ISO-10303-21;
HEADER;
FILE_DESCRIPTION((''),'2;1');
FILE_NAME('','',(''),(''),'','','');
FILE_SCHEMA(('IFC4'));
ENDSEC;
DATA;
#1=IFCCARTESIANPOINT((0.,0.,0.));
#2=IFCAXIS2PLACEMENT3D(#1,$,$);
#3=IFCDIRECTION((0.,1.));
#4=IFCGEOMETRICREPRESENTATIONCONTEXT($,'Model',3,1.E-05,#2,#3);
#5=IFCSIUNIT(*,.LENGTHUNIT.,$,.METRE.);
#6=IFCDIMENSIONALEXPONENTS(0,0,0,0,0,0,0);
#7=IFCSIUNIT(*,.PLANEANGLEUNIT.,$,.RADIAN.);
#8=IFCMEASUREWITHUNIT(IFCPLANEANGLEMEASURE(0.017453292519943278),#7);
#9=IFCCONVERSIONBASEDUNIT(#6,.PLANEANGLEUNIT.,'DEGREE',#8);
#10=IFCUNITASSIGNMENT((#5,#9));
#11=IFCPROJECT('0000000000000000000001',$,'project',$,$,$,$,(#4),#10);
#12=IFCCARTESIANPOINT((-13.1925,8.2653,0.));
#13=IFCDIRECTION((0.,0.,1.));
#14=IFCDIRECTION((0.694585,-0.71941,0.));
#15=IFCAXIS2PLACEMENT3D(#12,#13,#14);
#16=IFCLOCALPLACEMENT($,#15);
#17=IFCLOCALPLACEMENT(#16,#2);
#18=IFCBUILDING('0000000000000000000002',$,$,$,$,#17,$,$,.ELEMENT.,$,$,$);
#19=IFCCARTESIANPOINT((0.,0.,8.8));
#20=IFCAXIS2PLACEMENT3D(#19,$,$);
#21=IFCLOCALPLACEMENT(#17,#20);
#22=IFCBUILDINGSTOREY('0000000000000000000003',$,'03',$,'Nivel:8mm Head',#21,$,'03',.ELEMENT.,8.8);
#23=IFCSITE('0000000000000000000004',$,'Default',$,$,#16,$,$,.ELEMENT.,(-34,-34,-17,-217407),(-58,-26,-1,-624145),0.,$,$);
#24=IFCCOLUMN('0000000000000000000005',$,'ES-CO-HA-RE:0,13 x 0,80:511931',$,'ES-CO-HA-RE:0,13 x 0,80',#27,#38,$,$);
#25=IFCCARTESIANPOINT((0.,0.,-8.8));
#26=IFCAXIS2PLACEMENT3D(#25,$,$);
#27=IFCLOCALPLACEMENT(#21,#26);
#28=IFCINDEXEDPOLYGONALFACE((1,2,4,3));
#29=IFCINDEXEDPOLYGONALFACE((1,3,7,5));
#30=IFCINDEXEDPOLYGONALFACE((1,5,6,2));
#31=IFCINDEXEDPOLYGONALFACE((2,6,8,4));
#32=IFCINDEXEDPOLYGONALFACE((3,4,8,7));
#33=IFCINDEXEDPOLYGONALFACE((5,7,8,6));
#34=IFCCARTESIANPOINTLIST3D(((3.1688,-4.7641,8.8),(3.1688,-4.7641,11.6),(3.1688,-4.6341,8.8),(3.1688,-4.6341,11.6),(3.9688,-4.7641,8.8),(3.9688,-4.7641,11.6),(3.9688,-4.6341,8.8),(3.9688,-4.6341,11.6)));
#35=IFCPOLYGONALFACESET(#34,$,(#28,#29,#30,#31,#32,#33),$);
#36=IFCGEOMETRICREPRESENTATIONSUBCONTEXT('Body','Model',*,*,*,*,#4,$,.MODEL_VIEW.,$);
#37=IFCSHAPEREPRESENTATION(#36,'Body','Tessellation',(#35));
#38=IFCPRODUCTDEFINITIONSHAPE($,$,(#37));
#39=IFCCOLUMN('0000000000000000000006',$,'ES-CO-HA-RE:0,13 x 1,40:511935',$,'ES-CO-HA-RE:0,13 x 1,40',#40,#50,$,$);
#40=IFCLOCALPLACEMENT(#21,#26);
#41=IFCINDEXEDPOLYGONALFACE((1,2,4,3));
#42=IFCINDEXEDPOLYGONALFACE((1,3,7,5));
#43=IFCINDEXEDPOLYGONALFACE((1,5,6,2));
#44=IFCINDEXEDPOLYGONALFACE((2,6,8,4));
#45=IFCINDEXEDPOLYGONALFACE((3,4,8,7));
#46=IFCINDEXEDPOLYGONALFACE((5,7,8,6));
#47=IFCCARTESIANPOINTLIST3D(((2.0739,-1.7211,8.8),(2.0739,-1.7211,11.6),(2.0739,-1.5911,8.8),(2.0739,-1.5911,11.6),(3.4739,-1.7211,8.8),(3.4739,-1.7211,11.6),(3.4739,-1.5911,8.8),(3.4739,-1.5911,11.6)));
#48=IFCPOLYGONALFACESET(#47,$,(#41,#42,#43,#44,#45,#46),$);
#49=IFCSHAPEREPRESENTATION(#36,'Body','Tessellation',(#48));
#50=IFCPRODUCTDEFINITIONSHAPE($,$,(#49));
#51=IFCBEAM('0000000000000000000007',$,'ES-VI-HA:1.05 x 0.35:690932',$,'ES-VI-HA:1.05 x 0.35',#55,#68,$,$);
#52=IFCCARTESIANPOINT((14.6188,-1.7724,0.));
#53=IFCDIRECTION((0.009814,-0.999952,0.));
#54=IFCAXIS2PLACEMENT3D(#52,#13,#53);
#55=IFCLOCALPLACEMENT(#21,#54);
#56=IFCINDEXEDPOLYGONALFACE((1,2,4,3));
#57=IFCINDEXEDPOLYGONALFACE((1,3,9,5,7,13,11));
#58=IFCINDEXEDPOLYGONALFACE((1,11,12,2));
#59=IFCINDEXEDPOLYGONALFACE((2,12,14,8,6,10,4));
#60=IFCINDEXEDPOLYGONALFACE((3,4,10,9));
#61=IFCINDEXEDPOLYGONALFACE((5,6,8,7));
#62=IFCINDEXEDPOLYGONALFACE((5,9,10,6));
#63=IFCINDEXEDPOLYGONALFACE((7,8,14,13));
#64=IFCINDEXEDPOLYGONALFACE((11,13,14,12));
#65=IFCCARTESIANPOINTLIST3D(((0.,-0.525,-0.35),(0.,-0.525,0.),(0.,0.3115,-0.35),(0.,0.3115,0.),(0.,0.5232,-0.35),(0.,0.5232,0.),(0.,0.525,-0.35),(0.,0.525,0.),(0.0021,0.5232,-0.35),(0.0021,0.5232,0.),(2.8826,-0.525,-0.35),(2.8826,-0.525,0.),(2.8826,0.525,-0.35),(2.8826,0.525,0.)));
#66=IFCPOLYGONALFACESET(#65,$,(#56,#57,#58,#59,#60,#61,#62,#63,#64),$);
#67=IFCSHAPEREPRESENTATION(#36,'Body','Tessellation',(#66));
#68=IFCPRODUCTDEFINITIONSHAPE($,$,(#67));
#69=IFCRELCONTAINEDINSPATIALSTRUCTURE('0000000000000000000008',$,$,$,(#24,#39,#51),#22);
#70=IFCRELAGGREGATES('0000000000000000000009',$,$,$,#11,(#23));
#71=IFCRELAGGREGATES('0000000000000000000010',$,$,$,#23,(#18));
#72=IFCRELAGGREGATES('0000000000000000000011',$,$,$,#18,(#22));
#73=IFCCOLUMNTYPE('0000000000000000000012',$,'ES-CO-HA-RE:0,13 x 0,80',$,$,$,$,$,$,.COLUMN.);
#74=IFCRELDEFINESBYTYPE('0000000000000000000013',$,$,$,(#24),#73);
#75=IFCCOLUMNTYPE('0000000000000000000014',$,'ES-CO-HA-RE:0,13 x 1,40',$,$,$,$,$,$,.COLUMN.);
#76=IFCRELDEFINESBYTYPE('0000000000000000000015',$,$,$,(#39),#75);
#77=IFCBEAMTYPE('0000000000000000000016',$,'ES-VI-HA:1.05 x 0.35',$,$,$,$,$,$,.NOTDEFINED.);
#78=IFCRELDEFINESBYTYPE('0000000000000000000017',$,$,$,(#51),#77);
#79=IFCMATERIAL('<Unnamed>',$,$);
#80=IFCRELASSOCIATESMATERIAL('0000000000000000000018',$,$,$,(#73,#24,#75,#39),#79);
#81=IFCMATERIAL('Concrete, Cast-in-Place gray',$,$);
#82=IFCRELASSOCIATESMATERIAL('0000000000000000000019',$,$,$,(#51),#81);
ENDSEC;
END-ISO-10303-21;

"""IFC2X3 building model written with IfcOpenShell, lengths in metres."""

from ifc_helpers import new_model, entity, si_unit, converted_unit, direction, frame, frame_2d, origin, place, context, subcontext, project, spatial, polyline, rectangle, extrude, clip, bounded_halfspace, source, transform, mapped, material, type_object, type_shapes, element, save


model = new_model("IFC2X3")

# Units and contexts
model_context = context("Model", 3, precision=1e-05, world=origin(), true_north=direction((0.0, 1.0)))
body_context = subcontext(model_context, "Body", "Model", "MODEL_VIEW")
ifc_project = project(units=[si_unit("LENGTHUNIT", "METRE"), converted_unit("PLANEANGLEUNIT", "DEGREE", entity("IfcPlaneAngleMeasure", 0.017453292519943278), si_unit("PLANEANGLEUNIT", "RADIAN"), dimensions=[0, 0, 0, 0, 0, 0, 0])], contexts=[model_context])

# Site, building, storey
site_placement = place(None, frame((-13.1925, 8.2653, 0.0), z_axis=(0.0, 0.0, 1.0), x_axis=(0.694585, -0.71941, 0.0)))
site = spatial("IfcSite", under=ifc_project, at=site_placement, Name="Default", CompositionType="ELEMENT", RefLatitude=(-34, -34, -17, -217407), RefLongitude=(-58, -26, -1, -624145), RefElevation=0.0)
building_placement = place(site_placement, origin())
building = spatial("IfcBuilding", under=site, at=building_placement, CompositionType="ELEMENT")
storey_placement = place(building_placement, frame((0.0, 0.0, 8.8)))
storey = spatial("IfcBuildingStorey", under=building, at=storey_placement, Name="03", ObjectType="Nivel:8mm Head", LongName="03", CompositionType="ELEMENT", Elevation=8.8)

# Columns
ifc_material_1 = material(Name="<Unnamed>")
column_type_1 = type_object("IfcColumnType", Name="ES-CO-HA-RE:0,13 x 0,80", PredefinedType="COLUMN", material=ifc_material_1)
shared_shape_1 = source(origin(), body_context, "Body", "SweptSolid", [
    extrude(rectangle(XDim=0.8, YDim=0.13, at=frame_2d((0.0, 0.0), x_axis=(1.0, 0.0))), frame((3.5688, -4.6991, 8.8), z_axis=(0.0, 0.0, 1.0), x_axis=(-1.0, 0.0, 0.0)), (0.0, 0.0, 1.0), 2.8),
])
type_shapes(column_type_1, [shared_shape_1])
column_1_placement = place(storey_placement, frame((0.0, 0.0, -8.8)))
element("IfcColumn", 1, at=column_1_placement, inside=storey, type_object=column_type_1, material=ifc_material_1, Name="ES-CO-HA-RE:0,13 x 0,80:511931", ObjectType="ES-CO-HA-RE:0,13 x 0,80", context=body_context, shape_type="MappedRepresentation", body=[
    mapped(shared_shape_1, transform((0.0, 0.0, 0.0), scale=1.0)),
])
column_type_2 = type_object("IfcColumnType", Name="ES-CO-HA-RE:0,13 x 1,40", PredefinedType="COLUMN", material=ifc_material_1)
shared_shape_2 = source(origin(), body_context, "Body", "SweptSolid", [
    extrude(rectangle(XDim=1.4, YDim=0.13, at=frame_2d((0.0, 0.0), x_axis=(1.0, 0.0))), frame((2.7739, -1.6561, 8.8), z_axis=(0.0, 0.0, 1.0), x_axis=(-1.0, 0.0, 0.0)), (0.0, 0.0, 1.0), 2.8),
])
type_shapes(column_type_2, [shared_shape_2])
column_2_placement = place(storey_placement, frame((0.0, 0.0, -8.8)))
element("IfcColumn", 2, at=column_2_placement, inside=storey, type_object=column_type_2, material=ifc_material_1, Name="ES-CO-HA-RE:0,13 x 1,40:511935", ObjectType="ES-CO-HA-RE:0,13 x 1,40", context=body_context, shape_type="MappedRepresentation", body=[
    mapped(shared_shape_2, transform((0.0, 0.0, 0.0), scale=1.0)),
])

# Beam
ifc_material_2 = material(Name="Concrete, Cast-in-Place gray")
beam_type_1 = type_object("IfcBeamType", Name="ES-VI-HA:1.05 x 0.35", PredefinedType="NOTDEFINED")
beam_1_placement = place(storey_placement, frame((14.6188, -1.7724, 0.0), z_axis=(0.0, 0.0, 1.0), x_axis=(0.009814, -0.999952, 0.0)))
element("IfcBeam", 3, at=beam_1_placement, inside=storey, type_object=beam_type_1, material=ifc_material_2, Name="ES-VI-HA:1.05 x 0.35:690932", ObjectType="ES-VI-HA:1.05 x 0.35", context=body_context, shape_type="SweptSolid", body=[
    clip(clip(extrude(rectangle(XDim=0.35, YDim=1.05, at=frame_2d((0.0, 0.0), x_axis=(1.0, 0.0))), frame((0.0, 0.0, -0.175), z_axis=(1.0, 0.0, 0.0), x_axis=(0.0, 0.0, -1.0)), (0.0, 0.0, 1.0), 2.8826), bounded_halfspace(frame((0.0021, 0.5232, 0.0), z_axis=(-0.009814, -0.999952, 0.0), x_axis=(0.0, 0.0, -1.0)), False, frame((0.0, 0.0, -0.175), z_axis=(1.0, 0.0, 0.0), x_axis=(0.0, 0.0, -1.0)), polyline([(0.175, 0.5232), (-0.175, 0.5232), (-0.175, 0.5232), (0.175, 0.5232), (0.175, 0.5232)]))), bounded_halfspace(frame((-0.0082, -0.5268, 0.0), z_axis=(-0.999952, 0.009814, 0.0), x_axis=(0.0, 0.0, -1.0)), False, frame((0.0, 0.0, -0.175), z_axis=(1.0, 0.0, 0.0), x_axis=(0.0, 0.0, -1.0)), polyline([(-0.175, 0.5232), (0.175, 0.5232), (0.175, 0.3115), (-0.175, 0.3115), (-0.175, 0.5232)]))),
])

save(model, "model.ifc")
